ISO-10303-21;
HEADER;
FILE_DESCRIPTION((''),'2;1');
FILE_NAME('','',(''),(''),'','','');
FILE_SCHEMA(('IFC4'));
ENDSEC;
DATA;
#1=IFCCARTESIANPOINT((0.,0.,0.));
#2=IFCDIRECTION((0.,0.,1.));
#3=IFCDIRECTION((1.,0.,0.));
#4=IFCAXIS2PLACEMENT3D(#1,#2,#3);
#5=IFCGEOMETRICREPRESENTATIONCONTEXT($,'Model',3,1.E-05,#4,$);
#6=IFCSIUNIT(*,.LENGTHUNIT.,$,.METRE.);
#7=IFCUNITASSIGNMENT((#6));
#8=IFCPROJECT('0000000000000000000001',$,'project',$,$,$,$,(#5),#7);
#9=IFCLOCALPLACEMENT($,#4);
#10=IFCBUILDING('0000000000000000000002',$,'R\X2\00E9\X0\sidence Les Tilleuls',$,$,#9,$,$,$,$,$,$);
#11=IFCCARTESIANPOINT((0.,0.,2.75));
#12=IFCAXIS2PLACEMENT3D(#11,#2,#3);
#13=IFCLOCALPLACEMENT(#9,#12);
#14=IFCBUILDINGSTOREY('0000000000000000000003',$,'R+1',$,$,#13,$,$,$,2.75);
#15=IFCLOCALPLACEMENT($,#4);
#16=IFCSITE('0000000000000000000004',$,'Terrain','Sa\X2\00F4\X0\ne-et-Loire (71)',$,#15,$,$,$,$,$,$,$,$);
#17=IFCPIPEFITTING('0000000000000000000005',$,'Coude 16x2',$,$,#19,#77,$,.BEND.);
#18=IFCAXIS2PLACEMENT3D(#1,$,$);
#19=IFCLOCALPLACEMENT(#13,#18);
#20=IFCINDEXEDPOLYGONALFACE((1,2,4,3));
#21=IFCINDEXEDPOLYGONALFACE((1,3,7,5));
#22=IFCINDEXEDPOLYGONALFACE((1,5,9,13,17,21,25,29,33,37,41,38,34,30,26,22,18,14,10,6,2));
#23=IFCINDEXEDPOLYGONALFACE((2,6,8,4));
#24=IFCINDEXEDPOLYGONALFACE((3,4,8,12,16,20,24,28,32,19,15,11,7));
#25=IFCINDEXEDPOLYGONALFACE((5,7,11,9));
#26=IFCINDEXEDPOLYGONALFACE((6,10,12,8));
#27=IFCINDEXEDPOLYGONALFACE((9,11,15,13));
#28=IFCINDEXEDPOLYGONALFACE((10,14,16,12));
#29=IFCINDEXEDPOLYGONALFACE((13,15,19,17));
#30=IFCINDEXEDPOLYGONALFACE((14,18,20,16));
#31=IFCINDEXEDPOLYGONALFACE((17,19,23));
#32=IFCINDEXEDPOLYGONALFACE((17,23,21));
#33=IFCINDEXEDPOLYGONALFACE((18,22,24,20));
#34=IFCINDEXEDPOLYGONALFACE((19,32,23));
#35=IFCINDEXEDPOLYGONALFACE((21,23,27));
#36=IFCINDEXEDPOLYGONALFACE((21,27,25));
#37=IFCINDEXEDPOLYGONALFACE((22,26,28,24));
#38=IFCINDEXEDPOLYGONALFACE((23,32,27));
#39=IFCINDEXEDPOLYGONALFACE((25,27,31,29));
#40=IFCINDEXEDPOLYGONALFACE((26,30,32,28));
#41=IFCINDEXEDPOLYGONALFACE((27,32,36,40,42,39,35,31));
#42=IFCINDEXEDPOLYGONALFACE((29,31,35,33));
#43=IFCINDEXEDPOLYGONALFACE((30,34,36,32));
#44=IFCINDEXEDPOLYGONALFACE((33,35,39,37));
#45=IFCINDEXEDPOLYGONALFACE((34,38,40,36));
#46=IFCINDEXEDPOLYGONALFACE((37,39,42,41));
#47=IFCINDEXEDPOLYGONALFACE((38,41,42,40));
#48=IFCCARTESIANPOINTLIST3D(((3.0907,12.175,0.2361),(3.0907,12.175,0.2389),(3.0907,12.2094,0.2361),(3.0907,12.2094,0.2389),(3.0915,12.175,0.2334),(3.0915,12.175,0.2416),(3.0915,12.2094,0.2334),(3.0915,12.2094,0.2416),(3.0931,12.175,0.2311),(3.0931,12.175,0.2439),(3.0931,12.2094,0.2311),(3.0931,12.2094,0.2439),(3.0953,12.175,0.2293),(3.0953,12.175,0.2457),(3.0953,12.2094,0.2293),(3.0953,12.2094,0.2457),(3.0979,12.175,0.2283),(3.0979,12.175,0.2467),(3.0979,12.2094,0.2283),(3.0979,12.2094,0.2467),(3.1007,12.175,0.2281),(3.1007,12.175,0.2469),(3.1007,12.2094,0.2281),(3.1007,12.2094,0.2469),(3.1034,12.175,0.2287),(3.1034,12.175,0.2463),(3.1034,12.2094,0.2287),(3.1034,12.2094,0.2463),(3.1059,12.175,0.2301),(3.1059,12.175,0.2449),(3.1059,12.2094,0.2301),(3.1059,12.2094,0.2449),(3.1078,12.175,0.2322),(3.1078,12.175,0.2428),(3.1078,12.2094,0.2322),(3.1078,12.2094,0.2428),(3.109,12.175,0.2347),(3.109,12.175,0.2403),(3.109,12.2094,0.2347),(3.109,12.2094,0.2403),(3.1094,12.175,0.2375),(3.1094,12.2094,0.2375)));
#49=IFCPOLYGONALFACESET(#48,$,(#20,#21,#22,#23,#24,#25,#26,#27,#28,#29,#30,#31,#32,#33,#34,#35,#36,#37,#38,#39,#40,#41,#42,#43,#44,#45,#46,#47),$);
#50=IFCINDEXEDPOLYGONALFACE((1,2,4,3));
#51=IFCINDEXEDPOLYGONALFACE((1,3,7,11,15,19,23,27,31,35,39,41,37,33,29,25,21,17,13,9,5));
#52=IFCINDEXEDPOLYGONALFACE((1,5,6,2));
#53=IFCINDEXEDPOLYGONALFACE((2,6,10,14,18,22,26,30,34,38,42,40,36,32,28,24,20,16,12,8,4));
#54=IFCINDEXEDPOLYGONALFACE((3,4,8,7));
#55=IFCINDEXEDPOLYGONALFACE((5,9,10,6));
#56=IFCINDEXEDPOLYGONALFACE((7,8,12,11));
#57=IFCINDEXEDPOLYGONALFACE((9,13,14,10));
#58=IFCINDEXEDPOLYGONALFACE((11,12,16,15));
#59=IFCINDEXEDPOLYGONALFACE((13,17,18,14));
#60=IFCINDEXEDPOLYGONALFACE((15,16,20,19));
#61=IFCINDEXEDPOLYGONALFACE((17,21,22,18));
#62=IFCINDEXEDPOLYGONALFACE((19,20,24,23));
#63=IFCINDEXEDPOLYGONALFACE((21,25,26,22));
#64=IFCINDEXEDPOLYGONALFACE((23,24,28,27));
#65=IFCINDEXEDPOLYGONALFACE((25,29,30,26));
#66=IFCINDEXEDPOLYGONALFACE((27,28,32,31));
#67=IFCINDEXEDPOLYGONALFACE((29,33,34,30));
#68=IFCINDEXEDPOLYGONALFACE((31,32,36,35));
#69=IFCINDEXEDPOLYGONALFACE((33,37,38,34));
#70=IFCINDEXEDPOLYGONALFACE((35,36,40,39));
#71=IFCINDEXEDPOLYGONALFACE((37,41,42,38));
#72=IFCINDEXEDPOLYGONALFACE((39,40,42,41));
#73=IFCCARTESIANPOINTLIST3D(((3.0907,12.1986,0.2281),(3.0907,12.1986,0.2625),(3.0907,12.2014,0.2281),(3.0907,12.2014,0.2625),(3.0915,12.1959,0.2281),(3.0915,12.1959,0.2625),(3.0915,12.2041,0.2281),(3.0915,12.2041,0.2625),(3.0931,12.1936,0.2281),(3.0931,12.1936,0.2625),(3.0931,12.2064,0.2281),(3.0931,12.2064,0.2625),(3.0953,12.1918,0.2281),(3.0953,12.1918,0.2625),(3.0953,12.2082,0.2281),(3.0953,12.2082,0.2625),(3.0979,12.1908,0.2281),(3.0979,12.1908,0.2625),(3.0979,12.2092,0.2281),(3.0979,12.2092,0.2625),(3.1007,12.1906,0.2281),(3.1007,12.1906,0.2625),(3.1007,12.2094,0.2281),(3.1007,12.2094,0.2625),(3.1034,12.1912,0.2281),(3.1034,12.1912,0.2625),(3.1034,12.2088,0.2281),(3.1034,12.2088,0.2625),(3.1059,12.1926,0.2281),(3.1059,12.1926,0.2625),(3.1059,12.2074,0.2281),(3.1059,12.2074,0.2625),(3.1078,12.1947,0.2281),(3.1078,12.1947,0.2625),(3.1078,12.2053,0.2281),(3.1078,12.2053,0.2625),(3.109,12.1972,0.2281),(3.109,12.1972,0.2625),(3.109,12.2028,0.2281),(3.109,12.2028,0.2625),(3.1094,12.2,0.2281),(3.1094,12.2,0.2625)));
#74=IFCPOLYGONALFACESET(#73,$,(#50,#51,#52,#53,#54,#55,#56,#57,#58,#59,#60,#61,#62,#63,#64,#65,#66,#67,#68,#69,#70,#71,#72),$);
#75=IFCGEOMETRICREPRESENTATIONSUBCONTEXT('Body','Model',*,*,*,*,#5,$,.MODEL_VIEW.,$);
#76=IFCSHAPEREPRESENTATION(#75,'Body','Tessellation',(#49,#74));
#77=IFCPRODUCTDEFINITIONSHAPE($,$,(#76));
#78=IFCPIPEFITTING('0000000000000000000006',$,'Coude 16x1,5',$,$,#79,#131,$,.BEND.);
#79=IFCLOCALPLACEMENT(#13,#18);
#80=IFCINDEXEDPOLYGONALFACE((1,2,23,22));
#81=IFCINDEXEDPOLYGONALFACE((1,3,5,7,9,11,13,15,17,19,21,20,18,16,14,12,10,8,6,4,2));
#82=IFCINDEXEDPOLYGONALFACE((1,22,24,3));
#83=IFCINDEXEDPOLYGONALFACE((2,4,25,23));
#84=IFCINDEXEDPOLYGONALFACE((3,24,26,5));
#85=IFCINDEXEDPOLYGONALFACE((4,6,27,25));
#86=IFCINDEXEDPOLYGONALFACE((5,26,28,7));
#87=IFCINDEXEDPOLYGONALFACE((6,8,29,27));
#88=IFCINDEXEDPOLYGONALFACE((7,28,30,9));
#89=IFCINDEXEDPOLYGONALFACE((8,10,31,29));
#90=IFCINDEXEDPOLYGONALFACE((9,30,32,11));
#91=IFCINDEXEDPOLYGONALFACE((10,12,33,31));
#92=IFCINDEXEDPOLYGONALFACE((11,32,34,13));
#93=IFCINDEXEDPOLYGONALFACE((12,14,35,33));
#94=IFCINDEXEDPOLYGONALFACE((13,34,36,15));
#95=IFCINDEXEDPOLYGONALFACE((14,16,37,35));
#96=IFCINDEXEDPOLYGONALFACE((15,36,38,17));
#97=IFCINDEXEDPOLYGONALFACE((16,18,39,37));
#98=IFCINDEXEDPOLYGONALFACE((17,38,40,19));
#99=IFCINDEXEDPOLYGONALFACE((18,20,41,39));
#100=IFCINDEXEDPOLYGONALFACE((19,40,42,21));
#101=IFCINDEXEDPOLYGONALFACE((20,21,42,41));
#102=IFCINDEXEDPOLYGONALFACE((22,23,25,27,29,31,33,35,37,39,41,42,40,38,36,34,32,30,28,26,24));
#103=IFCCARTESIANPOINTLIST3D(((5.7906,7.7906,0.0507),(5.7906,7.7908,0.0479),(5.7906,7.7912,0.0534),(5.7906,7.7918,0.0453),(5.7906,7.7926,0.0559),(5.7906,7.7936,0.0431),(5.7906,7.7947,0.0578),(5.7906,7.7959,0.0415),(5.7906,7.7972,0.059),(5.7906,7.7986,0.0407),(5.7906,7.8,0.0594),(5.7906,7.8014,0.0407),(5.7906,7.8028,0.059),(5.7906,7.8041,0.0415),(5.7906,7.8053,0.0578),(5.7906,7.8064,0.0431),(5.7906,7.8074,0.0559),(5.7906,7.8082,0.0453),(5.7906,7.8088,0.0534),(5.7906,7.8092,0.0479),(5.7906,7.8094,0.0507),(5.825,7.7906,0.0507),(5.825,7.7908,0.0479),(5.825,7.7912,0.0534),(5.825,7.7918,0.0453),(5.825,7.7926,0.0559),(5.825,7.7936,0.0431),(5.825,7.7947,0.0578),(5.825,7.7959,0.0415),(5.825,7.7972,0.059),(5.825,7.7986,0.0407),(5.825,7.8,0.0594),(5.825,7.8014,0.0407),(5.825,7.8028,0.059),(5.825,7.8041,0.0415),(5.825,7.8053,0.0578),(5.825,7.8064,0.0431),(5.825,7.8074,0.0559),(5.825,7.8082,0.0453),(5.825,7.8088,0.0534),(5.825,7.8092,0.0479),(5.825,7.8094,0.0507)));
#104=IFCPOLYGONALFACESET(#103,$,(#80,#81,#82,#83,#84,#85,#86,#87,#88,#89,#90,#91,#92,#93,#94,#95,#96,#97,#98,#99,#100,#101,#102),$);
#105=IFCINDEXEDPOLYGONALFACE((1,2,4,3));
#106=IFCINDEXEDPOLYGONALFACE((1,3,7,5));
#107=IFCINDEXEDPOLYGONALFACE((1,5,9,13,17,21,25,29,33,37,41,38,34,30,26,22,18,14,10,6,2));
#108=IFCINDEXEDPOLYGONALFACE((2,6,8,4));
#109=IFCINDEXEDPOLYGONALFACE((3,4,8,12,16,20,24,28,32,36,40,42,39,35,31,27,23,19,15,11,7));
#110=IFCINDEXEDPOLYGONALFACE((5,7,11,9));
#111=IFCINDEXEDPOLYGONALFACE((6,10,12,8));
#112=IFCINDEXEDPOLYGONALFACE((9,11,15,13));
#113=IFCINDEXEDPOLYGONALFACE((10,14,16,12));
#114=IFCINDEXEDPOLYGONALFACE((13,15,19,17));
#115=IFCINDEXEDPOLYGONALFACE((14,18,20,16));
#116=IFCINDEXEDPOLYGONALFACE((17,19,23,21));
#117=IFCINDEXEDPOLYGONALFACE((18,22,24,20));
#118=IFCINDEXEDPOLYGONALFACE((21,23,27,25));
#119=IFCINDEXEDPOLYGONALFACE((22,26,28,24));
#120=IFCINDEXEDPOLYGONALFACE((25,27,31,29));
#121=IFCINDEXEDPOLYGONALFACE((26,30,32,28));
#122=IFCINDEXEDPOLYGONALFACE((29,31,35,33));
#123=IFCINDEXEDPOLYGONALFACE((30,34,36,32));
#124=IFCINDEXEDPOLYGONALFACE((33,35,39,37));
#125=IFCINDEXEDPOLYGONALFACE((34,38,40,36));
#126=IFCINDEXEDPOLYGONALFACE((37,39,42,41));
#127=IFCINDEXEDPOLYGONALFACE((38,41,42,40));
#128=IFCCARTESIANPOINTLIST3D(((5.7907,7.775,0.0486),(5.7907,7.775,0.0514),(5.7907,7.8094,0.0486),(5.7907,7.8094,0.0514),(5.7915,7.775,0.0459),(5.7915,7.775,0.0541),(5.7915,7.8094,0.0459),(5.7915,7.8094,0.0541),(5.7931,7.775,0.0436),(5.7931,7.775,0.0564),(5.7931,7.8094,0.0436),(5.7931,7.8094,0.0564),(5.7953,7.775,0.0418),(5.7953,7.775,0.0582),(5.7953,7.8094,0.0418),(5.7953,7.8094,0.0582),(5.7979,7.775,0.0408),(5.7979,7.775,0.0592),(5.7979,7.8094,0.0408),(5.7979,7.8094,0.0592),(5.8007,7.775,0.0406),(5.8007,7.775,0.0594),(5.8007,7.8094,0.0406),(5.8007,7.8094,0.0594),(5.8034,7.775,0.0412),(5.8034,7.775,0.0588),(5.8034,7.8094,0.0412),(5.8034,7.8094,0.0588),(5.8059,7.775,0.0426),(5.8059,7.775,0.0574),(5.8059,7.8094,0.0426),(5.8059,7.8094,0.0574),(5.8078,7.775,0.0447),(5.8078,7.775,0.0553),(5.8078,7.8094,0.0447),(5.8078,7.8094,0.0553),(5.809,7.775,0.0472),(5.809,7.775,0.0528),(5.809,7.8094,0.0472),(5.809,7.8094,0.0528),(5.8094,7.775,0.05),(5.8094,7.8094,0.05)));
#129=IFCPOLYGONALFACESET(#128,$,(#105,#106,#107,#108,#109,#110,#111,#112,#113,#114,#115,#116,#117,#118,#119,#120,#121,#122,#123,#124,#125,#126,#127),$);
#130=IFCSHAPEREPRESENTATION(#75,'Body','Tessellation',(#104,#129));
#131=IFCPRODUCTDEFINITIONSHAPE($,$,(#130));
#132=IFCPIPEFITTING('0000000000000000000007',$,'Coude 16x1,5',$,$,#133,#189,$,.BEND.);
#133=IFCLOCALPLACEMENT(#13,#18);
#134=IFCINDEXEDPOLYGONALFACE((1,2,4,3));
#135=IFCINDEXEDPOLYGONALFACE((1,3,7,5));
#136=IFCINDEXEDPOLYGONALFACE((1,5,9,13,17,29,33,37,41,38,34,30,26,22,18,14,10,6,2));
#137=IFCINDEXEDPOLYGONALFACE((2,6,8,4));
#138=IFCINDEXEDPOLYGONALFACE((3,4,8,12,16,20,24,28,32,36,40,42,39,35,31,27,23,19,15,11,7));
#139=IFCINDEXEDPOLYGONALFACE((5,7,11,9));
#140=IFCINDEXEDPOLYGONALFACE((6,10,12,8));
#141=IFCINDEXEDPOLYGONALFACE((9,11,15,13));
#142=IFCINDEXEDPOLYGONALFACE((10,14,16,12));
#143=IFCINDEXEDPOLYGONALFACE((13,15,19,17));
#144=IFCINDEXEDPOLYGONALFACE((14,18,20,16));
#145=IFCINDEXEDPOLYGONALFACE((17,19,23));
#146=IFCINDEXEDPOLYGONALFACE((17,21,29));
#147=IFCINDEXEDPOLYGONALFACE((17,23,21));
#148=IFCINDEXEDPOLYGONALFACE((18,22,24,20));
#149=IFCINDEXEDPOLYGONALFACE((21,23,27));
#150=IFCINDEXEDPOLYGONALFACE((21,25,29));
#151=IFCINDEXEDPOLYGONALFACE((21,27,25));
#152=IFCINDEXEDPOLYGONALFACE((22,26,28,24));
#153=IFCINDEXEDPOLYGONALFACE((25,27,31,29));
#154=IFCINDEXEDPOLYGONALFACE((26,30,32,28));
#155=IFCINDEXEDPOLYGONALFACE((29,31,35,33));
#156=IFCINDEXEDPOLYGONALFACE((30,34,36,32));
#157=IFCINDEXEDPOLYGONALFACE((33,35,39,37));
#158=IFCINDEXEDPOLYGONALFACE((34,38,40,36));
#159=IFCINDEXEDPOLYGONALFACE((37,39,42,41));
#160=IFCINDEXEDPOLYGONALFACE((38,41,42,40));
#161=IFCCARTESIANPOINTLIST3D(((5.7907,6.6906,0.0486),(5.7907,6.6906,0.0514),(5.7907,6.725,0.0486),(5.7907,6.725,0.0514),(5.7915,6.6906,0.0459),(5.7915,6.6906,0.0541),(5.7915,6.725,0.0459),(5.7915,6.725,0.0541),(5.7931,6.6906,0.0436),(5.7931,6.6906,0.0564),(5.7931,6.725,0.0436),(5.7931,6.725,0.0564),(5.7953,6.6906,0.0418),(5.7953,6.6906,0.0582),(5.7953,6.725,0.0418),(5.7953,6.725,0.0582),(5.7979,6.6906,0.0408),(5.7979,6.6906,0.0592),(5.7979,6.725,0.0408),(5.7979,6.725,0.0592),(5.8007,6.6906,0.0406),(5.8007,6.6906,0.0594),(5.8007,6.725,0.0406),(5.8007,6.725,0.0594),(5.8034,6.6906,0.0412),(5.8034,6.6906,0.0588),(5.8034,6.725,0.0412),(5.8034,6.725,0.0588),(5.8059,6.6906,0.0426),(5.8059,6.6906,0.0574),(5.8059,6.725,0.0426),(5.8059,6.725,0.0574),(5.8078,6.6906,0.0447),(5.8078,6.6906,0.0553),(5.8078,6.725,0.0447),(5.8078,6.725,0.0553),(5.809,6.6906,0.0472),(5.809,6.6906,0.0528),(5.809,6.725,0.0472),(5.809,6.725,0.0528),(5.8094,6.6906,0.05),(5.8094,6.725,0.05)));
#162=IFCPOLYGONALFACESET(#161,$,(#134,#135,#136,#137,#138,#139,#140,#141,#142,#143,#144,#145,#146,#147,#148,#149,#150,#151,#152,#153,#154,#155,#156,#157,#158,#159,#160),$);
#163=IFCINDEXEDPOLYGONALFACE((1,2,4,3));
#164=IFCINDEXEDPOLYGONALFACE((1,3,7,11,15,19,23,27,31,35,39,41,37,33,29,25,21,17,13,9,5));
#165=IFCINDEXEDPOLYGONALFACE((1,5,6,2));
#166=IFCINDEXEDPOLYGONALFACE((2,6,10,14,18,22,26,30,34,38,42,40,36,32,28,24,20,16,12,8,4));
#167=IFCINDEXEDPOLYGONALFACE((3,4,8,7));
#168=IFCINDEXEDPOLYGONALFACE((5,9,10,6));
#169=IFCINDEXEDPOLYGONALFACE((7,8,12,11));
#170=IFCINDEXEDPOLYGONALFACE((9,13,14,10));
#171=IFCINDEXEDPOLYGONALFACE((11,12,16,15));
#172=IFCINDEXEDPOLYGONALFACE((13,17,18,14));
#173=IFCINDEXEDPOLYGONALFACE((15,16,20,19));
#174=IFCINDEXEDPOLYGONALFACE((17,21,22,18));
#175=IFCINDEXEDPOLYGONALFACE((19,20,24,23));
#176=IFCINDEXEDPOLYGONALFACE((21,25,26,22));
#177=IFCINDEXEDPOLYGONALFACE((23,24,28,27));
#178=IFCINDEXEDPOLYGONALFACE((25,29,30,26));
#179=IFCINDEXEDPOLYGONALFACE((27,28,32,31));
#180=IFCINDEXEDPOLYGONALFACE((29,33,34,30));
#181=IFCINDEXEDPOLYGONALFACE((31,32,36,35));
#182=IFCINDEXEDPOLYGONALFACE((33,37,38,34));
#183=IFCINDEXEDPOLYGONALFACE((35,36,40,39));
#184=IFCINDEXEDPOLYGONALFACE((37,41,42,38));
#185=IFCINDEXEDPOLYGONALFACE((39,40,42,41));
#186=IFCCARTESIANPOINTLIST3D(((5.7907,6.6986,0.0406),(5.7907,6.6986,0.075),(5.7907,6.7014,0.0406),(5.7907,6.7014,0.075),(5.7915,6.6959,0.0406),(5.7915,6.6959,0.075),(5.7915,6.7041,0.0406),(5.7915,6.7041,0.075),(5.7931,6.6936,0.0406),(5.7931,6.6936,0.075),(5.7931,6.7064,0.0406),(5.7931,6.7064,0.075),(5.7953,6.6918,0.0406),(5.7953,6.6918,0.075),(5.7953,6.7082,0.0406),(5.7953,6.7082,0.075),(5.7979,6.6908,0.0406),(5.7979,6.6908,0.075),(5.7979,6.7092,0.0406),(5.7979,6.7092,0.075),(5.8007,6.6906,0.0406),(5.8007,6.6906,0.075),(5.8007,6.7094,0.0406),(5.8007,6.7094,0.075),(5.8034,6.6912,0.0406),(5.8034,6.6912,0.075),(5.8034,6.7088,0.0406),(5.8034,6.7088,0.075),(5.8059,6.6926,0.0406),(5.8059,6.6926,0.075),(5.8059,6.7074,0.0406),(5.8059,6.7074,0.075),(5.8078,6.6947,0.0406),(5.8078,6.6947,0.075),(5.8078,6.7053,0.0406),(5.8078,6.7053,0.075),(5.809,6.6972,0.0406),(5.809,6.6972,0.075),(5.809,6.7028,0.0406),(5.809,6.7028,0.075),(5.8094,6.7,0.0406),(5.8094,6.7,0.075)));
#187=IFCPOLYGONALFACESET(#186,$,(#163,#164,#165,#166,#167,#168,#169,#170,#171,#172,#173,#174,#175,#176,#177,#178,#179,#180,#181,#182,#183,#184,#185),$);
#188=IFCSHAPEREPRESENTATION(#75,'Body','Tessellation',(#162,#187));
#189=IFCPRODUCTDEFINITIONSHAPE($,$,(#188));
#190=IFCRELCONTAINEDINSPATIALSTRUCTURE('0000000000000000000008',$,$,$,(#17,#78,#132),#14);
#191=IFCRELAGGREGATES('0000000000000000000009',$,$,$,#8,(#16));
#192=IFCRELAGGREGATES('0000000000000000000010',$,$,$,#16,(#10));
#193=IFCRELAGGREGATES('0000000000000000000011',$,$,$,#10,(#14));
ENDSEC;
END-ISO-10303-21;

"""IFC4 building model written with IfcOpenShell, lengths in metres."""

from ifc_helpers import new_model, si_unit, frame, origin_with_axes, place, context, subcontext, project, spatial, circle, extrude, element, save


model = new_model("IFC4")

# Units and contexts
model_context = context("Model", 3, precision=1e-05, world=origin_with_axes())
body_context = subcontext(model_context, "Body", "Model", "MODEL_VIEW")
ifc_project = project(units=[si_unit("LENGTHUNIT", "METRE")], contexts=[model_context])

# Site, building, storey
site_placement = place(None, origin_with_axes())
site = spatial("IfcSite", under=ifc_project, at=site_placement, Name="Terrain", Description="Saône-et-Loire (71)")
building_placement = place(None, origin_with_axes())
building = spatial("IfcBuilding", under=site, at=building_placement, Name="Résidence Les Tilleuls")
storey_placement = place(building_placement, frame((0.0, 0.0, 2.75), z_axis=(0.0, 0.0, 1.0), x_axis=(1.0, 0.0, 0.0)))
storey = spatial("IfcBuildingStorey", under=building, at=storey_placement, Name="R+1", Elevation=2.75)

# Pipe fittings
for number, where, z_axis, x_axis, name in (
    (1, (3.1, 12.2, 0.2375), (0.0, 0.0, 1.0), (1.0, 0.0, 0.0), "Coude 16x2"),
):
    element("IfcPipeFitting", number, at=place(storey_placement, frame(where, z_axis=z_axis, x_axis=x_axis)), inside=storey, Name=name, PredefinedType="BEND", context=body_context, shape_type="SweptSolid", body=[
        extrude(circle(Radius=0.0094), frame((0.0, 0.0094, 0.0), z_axis=(0.0, -1.0, 0.0), x_axis=(1.0, 0.0, 0.0)), (0.0, 0.0, 1.0), 0.0344),
        extrude(circle(Radius=0.0094), frame((0.0, 0.0, -0.0094), z_axis=(0.0, 0.0, 1.0), x_axis=(1.0, 0.0, 0.0)), (0.0, 0.0, 1.0), 0.0344),
    ])
pipe_fitting_1_placement = place(storey_placement, frame((5.8, 7.8, 0.05), z_axis=(0.0, 0.0, 1.0), x_axis=(1.0, 0.0, 0.0)))
element("IfcPipeFitting", 2, at=pipe_fitting_1_placement, inside=storey, Name="Coude 16x1,5", PredefinedType="BEND", context=body_context, shape_type="SweptSolid", body=[
    extrude(circle(Radius=0.0094), frame((-0.0094, 0.0, 0.0), z_axis=(1.0, 0.0, 0.0), x_axis=(0.0, 0.0, 1.0)), (0.0, 0.0, 1.0), 0.0344),
    extrude(circle(Radius=0.0094), frame((0.0, 0.0094, 0.0), z_axis=(0.0, -1.0, 0.0), x_axis=(1.0, 0.0, 0.0)), (0.0, 0.0, 1.0), 0.0344),
])
pipe_fitting_2_placement = place(storey_placement, frame((5.8, 6.7, 0.05), z_axis=(0.0, 0.0, 1.0), x_axis=(1.0, 0.0, 0.0)))
element("IfcPipeFitting", 3, at=pipe_fitting_2_placement, inside=storey, Name="Coude 16x1,5", PredefinedType="BEND", context=body_context, shape_type="SweptSolid", body=[
    extrude(circle(Radius=0.0094), frame((0.0, -0.0094, 0.0), z_axis=(0.0, 1.0, 0.0), x_axis=(1.0, 0.0, 0.0)), (0.0, 0.0, 1.0), 0.0344),
    extrude(circle(Radius=0.0094), frame((0.0, 0.0, -0.0094), z_axis=(0.0, 0.0, 1.0), x_axis=(1.0, 0.0, 0.0)), (0.0, 0.0, 1.0), 0.0344),
])

save(model, "model.ifc")
